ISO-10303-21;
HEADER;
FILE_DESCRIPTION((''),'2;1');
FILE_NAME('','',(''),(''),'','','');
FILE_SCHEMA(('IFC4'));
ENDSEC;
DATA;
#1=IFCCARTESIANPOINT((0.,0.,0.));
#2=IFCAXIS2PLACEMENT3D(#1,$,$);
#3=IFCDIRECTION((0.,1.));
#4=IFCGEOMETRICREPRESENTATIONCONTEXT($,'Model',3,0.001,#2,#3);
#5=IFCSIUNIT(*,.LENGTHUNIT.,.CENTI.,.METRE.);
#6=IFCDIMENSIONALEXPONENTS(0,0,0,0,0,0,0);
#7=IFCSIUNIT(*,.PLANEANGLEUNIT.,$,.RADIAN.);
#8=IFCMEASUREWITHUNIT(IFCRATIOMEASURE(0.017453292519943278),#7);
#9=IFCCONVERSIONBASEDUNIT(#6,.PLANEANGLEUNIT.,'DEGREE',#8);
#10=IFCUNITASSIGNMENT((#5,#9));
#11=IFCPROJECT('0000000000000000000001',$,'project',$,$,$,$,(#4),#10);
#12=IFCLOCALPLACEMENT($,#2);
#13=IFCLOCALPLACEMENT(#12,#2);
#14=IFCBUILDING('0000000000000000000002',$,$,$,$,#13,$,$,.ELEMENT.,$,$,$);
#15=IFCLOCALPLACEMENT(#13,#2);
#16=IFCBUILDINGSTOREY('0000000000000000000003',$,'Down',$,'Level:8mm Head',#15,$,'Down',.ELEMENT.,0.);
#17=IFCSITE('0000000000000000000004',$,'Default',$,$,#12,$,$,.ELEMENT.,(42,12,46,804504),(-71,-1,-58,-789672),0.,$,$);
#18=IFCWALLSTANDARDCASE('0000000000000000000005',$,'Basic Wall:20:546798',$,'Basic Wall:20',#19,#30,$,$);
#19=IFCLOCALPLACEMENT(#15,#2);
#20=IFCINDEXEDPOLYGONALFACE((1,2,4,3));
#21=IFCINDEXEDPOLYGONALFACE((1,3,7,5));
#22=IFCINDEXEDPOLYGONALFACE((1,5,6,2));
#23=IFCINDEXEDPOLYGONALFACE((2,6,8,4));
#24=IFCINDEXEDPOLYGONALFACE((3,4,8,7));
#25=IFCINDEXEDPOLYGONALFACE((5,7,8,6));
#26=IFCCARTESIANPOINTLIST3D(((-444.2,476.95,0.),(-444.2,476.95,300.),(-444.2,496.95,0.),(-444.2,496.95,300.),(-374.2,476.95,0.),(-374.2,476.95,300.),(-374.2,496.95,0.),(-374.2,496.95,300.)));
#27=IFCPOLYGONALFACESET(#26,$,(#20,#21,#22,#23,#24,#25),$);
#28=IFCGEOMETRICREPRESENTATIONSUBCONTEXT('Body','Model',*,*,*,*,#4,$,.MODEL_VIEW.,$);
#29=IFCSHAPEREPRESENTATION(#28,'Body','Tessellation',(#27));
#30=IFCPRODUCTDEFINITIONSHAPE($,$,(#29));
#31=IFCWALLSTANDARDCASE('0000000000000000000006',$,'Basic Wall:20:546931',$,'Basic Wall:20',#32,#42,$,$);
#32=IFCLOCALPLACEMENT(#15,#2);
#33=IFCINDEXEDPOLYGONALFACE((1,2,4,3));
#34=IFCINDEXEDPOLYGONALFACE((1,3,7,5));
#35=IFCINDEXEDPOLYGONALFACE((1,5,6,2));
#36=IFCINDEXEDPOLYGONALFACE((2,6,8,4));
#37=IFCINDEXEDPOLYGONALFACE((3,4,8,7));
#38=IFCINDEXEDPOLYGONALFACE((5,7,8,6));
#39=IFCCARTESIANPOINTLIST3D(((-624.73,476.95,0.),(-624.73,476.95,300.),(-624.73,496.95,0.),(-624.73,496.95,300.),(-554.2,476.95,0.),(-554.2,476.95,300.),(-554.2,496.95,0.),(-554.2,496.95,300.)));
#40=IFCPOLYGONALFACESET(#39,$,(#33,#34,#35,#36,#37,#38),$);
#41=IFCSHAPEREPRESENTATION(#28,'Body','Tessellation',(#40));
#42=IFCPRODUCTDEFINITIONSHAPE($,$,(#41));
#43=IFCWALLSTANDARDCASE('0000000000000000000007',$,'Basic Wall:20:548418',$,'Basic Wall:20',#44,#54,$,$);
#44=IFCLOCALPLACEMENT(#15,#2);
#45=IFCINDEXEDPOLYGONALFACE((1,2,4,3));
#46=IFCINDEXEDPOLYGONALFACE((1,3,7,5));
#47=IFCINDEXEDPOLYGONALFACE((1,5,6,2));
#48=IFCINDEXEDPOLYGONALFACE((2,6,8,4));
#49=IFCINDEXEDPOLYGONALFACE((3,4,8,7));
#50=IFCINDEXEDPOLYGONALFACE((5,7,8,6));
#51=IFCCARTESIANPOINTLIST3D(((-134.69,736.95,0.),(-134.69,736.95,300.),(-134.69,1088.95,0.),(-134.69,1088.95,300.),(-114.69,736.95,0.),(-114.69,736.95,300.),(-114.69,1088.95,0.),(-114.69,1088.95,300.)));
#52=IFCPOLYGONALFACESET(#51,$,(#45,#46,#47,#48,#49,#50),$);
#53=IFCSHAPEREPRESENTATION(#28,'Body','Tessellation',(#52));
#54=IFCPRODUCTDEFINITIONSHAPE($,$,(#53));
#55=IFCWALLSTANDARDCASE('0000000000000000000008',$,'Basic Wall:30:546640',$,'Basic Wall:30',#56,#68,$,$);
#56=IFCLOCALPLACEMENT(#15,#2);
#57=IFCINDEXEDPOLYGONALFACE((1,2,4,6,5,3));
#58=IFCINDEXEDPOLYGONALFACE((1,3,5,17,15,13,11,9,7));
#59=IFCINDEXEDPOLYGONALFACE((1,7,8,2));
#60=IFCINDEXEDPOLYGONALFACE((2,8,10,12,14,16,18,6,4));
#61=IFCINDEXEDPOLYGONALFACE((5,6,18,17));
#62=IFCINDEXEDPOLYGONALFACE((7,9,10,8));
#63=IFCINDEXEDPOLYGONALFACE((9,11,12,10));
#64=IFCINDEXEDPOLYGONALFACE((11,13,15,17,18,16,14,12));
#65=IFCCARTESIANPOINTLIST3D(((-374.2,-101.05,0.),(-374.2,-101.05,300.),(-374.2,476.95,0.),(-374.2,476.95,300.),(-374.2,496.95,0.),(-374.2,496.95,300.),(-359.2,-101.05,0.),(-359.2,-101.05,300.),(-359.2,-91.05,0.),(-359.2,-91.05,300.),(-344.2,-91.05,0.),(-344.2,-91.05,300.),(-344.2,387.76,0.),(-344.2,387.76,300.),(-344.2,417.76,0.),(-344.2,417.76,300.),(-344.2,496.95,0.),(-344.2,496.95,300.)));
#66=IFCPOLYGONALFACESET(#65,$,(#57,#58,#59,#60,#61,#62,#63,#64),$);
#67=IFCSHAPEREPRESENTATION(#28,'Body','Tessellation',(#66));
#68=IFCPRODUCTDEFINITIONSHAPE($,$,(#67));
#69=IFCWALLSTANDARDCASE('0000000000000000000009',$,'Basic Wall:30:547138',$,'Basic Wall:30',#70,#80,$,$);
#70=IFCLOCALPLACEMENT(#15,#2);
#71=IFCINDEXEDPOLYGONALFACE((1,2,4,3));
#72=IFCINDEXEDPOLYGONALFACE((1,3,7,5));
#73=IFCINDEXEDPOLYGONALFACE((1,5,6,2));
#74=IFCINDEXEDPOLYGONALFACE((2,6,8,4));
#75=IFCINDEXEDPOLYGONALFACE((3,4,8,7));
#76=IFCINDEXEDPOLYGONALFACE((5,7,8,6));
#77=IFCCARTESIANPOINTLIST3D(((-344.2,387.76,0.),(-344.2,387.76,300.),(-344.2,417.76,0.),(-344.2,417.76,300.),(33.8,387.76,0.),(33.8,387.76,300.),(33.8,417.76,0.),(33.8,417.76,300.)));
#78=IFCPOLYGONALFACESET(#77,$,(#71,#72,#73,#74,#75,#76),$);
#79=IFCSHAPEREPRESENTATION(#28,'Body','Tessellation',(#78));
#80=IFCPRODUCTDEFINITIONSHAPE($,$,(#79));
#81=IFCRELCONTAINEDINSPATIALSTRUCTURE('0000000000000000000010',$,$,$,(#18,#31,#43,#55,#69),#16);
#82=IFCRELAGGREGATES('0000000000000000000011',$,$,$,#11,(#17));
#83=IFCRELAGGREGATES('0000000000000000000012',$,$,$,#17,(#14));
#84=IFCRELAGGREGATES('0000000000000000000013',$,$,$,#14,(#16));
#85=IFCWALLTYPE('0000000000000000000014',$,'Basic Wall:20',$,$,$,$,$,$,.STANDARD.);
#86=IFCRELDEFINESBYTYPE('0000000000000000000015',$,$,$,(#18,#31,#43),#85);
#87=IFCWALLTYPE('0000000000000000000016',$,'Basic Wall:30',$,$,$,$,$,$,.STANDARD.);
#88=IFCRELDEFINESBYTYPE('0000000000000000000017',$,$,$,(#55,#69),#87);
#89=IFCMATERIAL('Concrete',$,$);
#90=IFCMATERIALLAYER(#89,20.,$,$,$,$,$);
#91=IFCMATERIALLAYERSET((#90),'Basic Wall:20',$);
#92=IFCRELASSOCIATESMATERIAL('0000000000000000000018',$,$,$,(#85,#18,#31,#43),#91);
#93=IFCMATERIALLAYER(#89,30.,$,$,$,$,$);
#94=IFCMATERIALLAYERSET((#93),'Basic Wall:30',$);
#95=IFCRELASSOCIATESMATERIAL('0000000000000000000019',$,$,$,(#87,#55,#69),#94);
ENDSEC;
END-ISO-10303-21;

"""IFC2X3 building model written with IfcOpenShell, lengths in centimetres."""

from ifc_helpers import new_model, entity, si_unit, converted_unit, direction, frame, frame_2d, origin, place, context, subcontext, project, spatial, polyline, rectangle, outline, extrude, material, layer, layer_set, layer_usage, type_object, element, save


model = new_model("IFC2X3")

# Units and contexts
model_context = context("Model", 3, precision=0.001, world=origin(), true_north=direction((0.0, 1.0)))
body_context = subcontext(model_context, "Body", "Model", "MODEL_VIEW")
ifc_project = project(units=[si_unit("LENGTHUNIT", "METRE", prefix="CENTI"), converted_unit("PLANEANGLEUNIT", "DEGREE", entity("IfcRatioMeasure", 0.017453292519943278), si_unit("PLANEANGLEUNIT", "RADIAN"), dimensions=[0, 0, 0, 0, 0, 0, 0])], contexts=[model_context])

# Site, building, storey
site_placement = place(None, origin())
site = spatial("IfcSite", under=ifc_project, at=site_placement, Name="Default", CompositionType="ELEMENT", RefLatitude=(42, 12, 46, 804504), RefLongitude=(-71, -1, -58, -789672), RefElevation=0.0)
building_placement = place(site_placement, origin())
building = spatial("IfcBuilding", under=site, at=building_placement, CompositionType="ELEMENT")
storey_placement = place(building_placement, origin())
storey = spatial("IfcBuildingStorey", under=building, at=storey_placement, Name="Down", ObjectType="Level:8mm Head", LongName="Down", CompositionType="ELEMENT", Elevation=0.0)

# Shared definitions
ifc_material = material(Name="Concrete")

# Walls
ifc_layer_1 = layer(ifc_material, 20.0)
ifc_layer_set_1 = layer_set([ifc_layer_1], Name="Basic Wall:20")
wall_type_1 = type_object("IfcWallType", Name="Basic Wall:20", PredefinedType="STANDARD", material=ifc_layer_set_1)
ifc_layer_usage_1 = layer_usage(ifc_layer_set_1, "AXIS2", "POSITIVE", -10.0)
wall_1_placement = place(storey_placement, frame((-374.2, 486.95, 0.0), z_axis=(0.0, 0.0, 1.0), x_axis=(-1.0, 0.0, 0.0)))
element("IfcWallStandardCase", 1, at=wall_1_placement, inside=storey, type_object=wall_type_1, material=ifc_layer_usage_1, Name="Basic Wall:20:546798", ObjectType="Basic Wall:20", context=body_context, shape_type="SweptSolid", body=[
    extrude(rectangle(XDim=70.0, YDim=20.0, at=frame_2d((35.0, 0.0), x_axis=(-1.0, 0.0))), origin(), (0.0, 0.0, 1.0), 300.0),
])
ifc_layer_usage_2 = layer_usage(ifc_layer_set_1, "AXIS2", "POSITIVE", -10.0)
wall_2_placement = place(storey_placement, frame((-554.2, 486.95, 0.0), z_axis=(0.0, 0.0, 1.0), x_axis=(-1.0, 0.0, 0.0)))
element("IfcWallStandardCase", 2, at=wall_2_placement, inside=storey, type_object=wall_type_1, material=ifc_layer_usage_2, Name="Basic Wall:20:546931", ObjectType="Basic Wall:20", context=body_context, shape_type="SweptSolid", body=[
    extrude(rectangle(XDim=70.53, YDim=20.0, at=frame_2d((35.27, 0.0), x_axis=(-1.0, 0.0))), origin(), (0.0, 0.0, 1.0), 300.0),
])
ifc_layer_usage_3 = layer_usage(ifc_layer_set_1, "AXIS2", "POSITIVE", -10.0)
wall_3_placement = place(storey_placement, frame((-124.69, 1088.95, 0.0), z_axis=(0.0, 0.0, 1.0), x_axis=(0.0, -1.0, 0.0)))
element("IfcWallStandardCase", 3, at=wall_3_placement, inside=storey, type_object=wall_type_1, material=ifc_layer_usage_3, Name="Basic Wall:20:548418", ObjectType="Basic Wall:20", context=body_context, shape_type="SweptSolid", body=[
    extrude(rectangle(XDim=352.0, YDim=20.0, at=frame_2d((176.0, 0.0), x_axis=(-1.0, 0.0))), origin(), (0.0, 0.0, 1.0), 300.0),
])
ifc_layer_2 = layer(ifc_material, 30.0)
ifc_layer_set_2 = layer_set([ifc_layer_2], Name="Basic Wall:30")
ifc_layer_usage_4 = layer_usage(ifc_layer_set_2, "AXIS2", "NEGATIVE", 15.0)
wall_type_2 = type_object("IfcWallType", Name="Basic Wall:30", PredefinedType="STANDARD", material=ifc_layer_set_2)
wall_4_placement = place(storey_placement, frame((-359.2, -101.05, 0.0), z_axis=(0.0, 0.0, 1.0), x_axis=(0.0, 1.0, 0.0)))
element("IfcWallStandardCase", 4, at=wall_4_placement, inside=storey, type_object=wall_type_2, material=ifc_layer_usage_4, Name="Basic Wall:30:546640", ObjectType="Basic Wall:30", context=body_context, shape_type="SweptSolid", body=[
    extrude(outline(polyline([(598.0, -15.0), (598.0, 15.0), (578.0, 15.0), (0.0, 15.0), (0.0, 0.0), (10.0, 0.0), (10.0, -15.0), (488.81, -15.0), (518.81, -15.0), (598.0, -15.0)])), origin(), (0.0, 0.0, 1.0), 300.0),
])
ifc_layer_usage_5 = layer_usage(ifc_layer_set_2, "AXIS2", "NEGATIVE", 15.0)
wall_5_placement = place(storey_placement, frame((-344.2, 402.76, 0.0)))
element("IfcWallStandardCase", 5, at=wall_5_placement, inside=storey, type_object=wall_type_2, material=ifc_layer_usage_5, Name="Basic Wall:30:547138", ObjectType="Basic Wall:30", context=body_context, shape_type="SweptSolid", body=[
    extrude(rectangle(XDim=378.0, YDim=30.0, at=frame_2d((189.0, 0.0), x_axis=(-1.0, 0.0))), origin(), (0.0, 0.0, 1.0), 300.0),
])

save(model, "model.ifc")
